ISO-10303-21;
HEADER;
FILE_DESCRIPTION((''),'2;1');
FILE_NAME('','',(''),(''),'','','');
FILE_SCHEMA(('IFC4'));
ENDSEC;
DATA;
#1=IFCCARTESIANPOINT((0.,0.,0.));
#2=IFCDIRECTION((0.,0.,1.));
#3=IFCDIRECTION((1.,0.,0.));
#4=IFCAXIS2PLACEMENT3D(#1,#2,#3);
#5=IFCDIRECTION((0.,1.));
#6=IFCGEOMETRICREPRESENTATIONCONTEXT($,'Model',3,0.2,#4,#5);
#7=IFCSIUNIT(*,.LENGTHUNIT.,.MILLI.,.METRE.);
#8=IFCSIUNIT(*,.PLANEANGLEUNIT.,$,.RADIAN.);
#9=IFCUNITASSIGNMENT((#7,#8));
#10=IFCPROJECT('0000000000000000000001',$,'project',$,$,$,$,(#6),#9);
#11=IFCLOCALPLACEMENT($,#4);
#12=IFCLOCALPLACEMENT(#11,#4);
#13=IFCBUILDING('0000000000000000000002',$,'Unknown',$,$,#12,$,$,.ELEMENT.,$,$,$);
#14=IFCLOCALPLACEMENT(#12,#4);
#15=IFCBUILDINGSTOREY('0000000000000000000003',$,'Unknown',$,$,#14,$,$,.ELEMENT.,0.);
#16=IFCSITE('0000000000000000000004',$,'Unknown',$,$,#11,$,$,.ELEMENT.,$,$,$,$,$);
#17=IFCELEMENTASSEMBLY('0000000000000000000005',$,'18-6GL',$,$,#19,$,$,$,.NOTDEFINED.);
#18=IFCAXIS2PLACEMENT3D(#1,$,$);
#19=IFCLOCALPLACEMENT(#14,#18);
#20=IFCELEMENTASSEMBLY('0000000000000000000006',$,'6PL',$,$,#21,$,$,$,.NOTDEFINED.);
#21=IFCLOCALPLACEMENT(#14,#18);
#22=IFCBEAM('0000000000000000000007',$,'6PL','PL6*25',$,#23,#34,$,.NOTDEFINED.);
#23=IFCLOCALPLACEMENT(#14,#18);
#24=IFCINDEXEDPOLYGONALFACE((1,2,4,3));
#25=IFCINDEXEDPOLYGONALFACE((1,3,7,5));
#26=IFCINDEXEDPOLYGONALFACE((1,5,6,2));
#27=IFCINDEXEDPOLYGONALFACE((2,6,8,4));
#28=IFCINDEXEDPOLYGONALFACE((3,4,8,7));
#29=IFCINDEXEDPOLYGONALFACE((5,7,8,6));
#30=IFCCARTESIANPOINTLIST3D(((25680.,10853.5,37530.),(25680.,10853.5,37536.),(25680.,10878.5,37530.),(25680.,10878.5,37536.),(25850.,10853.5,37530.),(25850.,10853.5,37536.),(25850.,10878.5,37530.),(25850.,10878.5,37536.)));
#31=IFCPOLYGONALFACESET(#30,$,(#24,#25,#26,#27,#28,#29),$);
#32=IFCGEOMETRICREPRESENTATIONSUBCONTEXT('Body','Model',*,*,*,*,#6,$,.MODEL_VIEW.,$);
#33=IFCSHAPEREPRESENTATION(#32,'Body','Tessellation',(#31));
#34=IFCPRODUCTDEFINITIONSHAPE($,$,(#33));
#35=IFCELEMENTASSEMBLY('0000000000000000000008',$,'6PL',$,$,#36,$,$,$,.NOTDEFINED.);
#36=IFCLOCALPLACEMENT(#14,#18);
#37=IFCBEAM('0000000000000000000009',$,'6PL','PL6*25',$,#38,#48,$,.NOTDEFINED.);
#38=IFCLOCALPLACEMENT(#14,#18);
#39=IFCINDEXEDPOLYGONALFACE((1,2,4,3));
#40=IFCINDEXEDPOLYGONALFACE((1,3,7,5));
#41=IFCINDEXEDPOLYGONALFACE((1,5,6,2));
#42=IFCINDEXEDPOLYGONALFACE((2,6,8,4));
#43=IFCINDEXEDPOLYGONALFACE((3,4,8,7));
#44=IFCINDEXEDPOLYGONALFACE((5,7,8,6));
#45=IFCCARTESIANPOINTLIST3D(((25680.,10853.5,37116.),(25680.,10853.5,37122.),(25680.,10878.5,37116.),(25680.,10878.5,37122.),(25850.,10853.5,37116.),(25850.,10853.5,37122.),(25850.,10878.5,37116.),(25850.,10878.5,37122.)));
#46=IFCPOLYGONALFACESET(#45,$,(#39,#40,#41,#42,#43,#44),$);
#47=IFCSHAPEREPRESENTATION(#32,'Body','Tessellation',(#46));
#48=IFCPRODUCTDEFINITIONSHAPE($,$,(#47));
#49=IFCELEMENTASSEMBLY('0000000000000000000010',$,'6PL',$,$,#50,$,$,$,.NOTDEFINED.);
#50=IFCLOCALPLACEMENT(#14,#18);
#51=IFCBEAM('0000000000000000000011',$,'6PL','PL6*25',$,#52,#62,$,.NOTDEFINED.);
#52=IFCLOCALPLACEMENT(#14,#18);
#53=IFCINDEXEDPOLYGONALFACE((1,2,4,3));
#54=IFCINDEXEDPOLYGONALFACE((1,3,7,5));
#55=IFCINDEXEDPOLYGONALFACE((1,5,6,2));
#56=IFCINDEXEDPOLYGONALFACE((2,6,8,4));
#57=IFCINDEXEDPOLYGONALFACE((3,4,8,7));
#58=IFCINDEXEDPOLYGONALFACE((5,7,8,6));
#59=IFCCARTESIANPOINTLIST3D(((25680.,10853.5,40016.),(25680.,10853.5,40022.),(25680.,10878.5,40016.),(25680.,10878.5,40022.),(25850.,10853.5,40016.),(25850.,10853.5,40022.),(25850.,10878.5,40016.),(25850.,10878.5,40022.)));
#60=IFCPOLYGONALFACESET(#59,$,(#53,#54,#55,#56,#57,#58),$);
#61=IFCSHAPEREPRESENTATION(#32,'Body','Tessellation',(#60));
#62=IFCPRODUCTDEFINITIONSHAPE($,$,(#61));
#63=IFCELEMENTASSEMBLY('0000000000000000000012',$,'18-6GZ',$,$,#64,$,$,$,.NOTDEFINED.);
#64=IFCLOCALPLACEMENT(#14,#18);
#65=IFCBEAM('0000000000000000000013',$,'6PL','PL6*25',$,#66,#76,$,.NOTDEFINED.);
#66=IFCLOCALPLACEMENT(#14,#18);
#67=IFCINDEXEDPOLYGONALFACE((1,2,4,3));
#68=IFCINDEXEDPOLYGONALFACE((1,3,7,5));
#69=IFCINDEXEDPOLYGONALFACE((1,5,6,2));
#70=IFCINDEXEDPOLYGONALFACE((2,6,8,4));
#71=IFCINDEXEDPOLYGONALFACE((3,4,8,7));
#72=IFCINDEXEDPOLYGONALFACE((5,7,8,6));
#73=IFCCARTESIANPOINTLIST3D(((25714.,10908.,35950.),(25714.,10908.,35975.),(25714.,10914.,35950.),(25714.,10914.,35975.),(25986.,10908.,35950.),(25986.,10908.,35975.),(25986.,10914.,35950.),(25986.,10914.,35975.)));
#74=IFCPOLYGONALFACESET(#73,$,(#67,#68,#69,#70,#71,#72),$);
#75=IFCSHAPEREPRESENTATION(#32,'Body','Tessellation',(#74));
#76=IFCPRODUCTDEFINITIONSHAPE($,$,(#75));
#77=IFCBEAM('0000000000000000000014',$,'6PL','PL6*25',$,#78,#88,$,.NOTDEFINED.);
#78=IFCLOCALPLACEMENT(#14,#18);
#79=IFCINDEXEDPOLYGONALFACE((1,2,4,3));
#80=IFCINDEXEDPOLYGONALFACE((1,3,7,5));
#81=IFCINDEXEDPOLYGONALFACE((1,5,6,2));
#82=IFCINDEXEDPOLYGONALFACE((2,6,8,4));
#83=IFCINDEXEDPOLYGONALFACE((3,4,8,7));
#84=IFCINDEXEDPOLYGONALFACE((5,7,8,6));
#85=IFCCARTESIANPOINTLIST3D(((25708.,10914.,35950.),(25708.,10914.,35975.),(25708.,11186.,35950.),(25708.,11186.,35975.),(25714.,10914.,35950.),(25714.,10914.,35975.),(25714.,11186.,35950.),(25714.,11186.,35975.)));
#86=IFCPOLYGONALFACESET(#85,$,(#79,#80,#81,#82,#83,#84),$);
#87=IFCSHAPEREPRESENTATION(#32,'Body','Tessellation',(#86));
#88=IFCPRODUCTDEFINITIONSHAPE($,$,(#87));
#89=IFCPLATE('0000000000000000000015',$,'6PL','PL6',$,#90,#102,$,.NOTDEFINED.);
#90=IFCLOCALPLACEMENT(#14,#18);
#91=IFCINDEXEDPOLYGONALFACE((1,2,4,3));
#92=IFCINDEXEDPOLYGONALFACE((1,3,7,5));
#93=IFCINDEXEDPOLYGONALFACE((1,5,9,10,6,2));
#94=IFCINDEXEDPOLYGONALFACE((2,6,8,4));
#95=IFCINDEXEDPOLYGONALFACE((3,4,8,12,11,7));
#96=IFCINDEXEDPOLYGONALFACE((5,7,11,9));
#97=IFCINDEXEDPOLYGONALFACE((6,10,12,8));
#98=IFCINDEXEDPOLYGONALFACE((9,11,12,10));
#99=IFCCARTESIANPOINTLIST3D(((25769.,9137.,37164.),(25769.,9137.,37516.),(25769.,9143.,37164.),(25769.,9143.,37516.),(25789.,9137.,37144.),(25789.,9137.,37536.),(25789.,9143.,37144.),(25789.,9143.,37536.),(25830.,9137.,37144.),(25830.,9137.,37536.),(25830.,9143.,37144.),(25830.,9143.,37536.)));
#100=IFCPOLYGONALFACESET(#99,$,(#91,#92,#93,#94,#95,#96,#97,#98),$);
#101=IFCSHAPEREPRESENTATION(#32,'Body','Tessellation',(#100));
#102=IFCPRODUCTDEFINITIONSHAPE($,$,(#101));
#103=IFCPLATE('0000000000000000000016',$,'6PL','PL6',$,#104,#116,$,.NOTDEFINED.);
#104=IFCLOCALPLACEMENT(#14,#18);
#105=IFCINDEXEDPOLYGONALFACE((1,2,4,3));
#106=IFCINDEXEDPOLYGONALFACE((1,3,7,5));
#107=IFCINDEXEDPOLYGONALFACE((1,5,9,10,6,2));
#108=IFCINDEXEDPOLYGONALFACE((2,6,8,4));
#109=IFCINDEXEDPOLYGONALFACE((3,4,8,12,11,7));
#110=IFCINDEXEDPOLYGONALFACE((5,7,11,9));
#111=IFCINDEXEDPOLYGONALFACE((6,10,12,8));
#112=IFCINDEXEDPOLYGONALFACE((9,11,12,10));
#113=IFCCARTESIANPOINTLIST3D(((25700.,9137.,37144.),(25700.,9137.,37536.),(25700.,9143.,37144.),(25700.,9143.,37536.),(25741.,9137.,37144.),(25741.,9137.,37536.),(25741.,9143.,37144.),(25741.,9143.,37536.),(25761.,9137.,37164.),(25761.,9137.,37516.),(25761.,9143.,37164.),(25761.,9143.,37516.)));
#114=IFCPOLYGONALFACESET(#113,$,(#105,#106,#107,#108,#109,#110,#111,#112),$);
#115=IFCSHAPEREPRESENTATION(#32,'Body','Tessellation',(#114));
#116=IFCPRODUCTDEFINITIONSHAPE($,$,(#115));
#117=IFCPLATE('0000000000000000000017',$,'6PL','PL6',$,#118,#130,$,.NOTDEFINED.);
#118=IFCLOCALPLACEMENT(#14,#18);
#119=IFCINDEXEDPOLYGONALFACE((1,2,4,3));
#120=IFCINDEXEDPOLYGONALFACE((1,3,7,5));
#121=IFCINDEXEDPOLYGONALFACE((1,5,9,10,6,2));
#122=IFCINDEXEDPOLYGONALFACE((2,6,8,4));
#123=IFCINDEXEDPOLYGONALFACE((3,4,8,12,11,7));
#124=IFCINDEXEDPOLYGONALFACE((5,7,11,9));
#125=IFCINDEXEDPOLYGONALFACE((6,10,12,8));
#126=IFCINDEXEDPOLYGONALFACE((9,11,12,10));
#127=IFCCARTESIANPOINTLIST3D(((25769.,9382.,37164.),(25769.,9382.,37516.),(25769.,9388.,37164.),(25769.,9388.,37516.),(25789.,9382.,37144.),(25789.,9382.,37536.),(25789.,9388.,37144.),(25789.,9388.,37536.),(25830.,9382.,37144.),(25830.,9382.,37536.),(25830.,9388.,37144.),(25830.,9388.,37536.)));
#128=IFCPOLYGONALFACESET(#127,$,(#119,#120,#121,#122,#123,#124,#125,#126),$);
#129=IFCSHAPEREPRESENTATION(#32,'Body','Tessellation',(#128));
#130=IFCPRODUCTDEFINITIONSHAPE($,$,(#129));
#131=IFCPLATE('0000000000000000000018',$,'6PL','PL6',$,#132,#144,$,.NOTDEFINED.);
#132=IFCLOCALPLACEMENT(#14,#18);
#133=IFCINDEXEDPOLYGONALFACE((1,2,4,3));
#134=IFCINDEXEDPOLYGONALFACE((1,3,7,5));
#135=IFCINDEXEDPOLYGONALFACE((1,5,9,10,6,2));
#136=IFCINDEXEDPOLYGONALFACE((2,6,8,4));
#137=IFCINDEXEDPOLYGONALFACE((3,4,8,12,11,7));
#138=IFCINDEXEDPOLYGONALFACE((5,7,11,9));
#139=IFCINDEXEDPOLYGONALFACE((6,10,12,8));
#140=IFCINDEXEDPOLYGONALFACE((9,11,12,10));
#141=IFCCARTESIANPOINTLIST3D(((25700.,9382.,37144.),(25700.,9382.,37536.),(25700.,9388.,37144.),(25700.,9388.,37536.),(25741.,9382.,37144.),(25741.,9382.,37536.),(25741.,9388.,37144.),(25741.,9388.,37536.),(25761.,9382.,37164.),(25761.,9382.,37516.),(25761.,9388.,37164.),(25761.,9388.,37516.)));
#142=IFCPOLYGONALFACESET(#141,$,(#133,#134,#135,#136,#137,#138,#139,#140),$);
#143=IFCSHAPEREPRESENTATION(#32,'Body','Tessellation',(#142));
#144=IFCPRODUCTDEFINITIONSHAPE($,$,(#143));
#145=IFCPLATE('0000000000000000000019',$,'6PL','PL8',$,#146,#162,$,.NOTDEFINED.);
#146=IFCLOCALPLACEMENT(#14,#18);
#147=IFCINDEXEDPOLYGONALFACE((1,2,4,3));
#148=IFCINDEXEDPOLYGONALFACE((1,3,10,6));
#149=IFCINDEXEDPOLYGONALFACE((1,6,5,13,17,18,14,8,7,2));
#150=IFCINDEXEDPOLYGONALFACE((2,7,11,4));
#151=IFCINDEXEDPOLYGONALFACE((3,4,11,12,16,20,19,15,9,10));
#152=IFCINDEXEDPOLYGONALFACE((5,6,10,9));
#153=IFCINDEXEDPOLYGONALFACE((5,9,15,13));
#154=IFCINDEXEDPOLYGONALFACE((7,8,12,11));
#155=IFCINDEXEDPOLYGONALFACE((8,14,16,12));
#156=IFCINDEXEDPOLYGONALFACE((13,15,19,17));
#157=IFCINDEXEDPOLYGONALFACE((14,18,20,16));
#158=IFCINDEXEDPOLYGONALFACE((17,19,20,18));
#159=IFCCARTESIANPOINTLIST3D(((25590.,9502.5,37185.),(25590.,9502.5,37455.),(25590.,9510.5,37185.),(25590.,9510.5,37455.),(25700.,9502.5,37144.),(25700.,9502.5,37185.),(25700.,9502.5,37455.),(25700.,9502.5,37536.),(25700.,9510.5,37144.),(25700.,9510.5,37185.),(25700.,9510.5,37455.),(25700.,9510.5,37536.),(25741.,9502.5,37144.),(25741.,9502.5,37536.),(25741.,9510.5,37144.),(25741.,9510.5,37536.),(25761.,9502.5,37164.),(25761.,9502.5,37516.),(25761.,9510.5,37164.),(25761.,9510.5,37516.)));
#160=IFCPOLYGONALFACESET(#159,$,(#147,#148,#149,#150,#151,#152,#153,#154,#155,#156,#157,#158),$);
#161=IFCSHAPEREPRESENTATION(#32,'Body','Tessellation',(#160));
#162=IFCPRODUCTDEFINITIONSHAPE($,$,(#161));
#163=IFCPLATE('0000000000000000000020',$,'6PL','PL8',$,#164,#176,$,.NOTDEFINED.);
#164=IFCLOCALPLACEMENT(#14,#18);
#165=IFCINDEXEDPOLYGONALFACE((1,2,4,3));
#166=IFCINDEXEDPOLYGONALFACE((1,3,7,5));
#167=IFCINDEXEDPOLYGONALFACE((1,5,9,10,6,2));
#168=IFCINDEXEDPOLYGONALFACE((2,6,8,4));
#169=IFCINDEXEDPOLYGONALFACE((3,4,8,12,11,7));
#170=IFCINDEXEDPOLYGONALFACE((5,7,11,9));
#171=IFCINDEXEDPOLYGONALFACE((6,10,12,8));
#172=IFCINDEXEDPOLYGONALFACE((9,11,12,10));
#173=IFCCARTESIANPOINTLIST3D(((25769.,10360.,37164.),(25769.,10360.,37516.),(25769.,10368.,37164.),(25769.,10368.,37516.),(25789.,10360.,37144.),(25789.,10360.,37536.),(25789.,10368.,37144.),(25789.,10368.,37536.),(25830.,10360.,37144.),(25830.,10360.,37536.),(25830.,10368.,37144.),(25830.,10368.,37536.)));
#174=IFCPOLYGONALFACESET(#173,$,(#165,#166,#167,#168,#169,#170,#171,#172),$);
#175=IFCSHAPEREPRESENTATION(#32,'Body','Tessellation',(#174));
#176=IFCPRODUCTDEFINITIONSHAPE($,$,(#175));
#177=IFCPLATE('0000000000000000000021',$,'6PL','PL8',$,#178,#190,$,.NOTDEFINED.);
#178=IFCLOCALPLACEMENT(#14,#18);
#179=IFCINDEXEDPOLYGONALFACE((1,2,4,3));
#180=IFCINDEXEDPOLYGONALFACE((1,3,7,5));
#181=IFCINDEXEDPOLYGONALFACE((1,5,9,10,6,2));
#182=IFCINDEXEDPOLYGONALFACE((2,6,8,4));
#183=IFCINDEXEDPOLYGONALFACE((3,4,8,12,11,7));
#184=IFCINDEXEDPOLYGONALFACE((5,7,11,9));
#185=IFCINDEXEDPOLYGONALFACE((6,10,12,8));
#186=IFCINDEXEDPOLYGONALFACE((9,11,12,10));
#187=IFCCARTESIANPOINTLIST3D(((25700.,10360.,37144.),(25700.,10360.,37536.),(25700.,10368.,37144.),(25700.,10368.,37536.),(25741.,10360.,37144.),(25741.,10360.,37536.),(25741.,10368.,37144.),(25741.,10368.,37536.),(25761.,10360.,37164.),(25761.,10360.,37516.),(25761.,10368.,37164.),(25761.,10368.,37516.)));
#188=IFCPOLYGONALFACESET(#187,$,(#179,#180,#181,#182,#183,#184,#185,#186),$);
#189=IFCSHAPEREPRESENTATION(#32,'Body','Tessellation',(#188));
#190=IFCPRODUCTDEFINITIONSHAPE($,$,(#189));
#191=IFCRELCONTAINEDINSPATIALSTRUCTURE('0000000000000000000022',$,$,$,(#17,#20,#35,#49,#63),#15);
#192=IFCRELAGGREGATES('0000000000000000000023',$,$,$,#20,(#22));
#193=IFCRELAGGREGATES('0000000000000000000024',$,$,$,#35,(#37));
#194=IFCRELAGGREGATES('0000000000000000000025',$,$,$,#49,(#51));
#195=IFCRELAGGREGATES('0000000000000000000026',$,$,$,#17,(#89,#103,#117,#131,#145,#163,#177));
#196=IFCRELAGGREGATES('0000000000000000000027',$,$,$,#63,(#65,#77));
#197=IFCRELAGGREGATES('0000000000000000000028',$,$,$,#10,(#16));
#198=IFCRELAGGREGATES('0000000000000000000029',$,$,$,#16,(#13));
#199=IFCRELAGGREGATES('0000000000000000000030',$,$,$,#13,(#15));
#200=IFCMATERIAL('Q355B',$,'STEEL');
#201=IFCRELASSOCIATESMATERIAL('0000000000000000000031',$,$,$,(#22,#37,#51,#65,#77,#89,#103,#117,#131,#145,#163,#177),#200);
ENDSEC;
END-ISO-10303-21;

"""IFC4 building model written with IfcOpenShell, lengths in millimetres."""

from ifc_helpers import new_model, si_unit, direction, frame, origin_with_axes, place, context, subcontext, project, spatial, line, indexed_curve, outline, extrude, material, element, aggregate, save


model = new_model("IFC4")

# Units and contexts
model_context = context("Model", 3, precision=0.2, world=origin_with_axes(), true_north=direction((0.0, 1.0)))
body_context = subcontext(model_context, "Body", "Model", "MODEL_VIEW")
ifc_project = project(units=[si_unit("LENGTHUNIT", "METRE", prefix="MILLI"), si_unit("PLANEANGLEUNIT", "RADIAN")], contexts=[model_context])

# Site, building, storey
site_placement = place(None, origin_with_axes())
site = spatial("IfcSite", under=ifc_project, at=site_placement, Name="Unknown", CompositionType="ELEMENT")
building_placement = place(site_placement, origin_with_axes())
building = spatial("IfcBuilding", under=site, at=building_placement, Name="Unknown", CompositionType="ELEMENT")
storey_placement = place(building_placement, origin_with_axes())
storey = spatial("IfcBuildingStorey", under=building, at=storey_placement, Name="Unknown", CompositionType="ELEMENT", Elevation=0.0)

# Element assembly
assembly_1_placement = place(storey_placement, frame((25765.0, 10900.0, 37340.0), z_axis=(-1.0, 0.0, 0.0), x_axis=(0.0, -1.0, 0.0)))
assembly_1 = element("IfcElementAssembly", 1, at=assembly_1_placement, inside=storey, Name="18-6GL", PredefinedType="NOTDEFINED")
ifc_material_1 = material(Name="Q355B", Category="STEEL")

# Element assemblies, beams
assembly_2_placement = place(storey_placement, frame((25680.0, 10866.0, 37533.0), z_axis=(0.0, 0.0, -1.0), x_axis=(1.0, 0.0, 0.0)))
assembly_2 = element("IfcElementAssembly", 2, at=assembly_2_placement, inside=storey, Name="6PL", PredefinedType="NOTDEFINED")
beam_1_placement = place(assembly_2_placement, origin_with_axes())
beam_1 = element("IfcBeam", 3, at=beam_1_placement, material=ifc_material_1, Name="6PL", Description="PL6*25", PredefinedType="NOTDEFINED", context=body_context, shape_type="SolidModel", body=[
    extrude(outline(indexed_curve([(-3.0, -12.5), (3.0, -12.5), (3.0, 12.5), (-3.0, 12.5)], segments=[line(1, 2, 3, 4, 1)])), frame((0.0, 0.0, 0.0), z_axis=(-1.0, 0.0, 0.0), x_axis=(0.0, 0.0, 1.0)), (0.0, 0.0, -1.0), 170.0),
])
aggregate(assembly_2, [beam_1])
assembly_3_placement = place(storey_placement, frame((25680.0, 10866.0, 37119.0), z_axis=(0.0, 0.0, -1.0), x_axis=(1.0, 0.0, 0.0)))
assembly_3 = element("IfcElementAssembly", 4, at=assembly_3_placement, inside=storey, Name="6PL", PredefinedType="NOTDEFINED")
beam_2_placement = place(assembly_3_placement, origin_with_axes())
beam_2 = element("IfcBeam", 5, at=beam_2_placement, material=ifc_material_1, Name="6PL", Description="PL6*25", PredefinedType="NOTDEFINED", context=body_context, shape_type="SolidModel", body=[
    extrude(outline(indexed_curve([(-3.0, -12.5), (3.0, -12.5), (3.0, 12.5), (-3.0, 12.5)], segments=[line(1, 2, 3, 4, 1)])), frame((0.0, 0.0, 0.0), z_axis=(-1.0, 0.0, 0.0), x_axis=(0.0, 0.0, 1.0)), (0.0, 0.0, -1.0), 170.0),
])
aggregate(assembly_3, [beam_2])
assembly_4_placement = place(storey_placement, frame((25680.0, 10866.0, 40019.0), z_axis=(0.0, 0.0, -1.0), x_axis=(1.0, 0.0, 0.0)))
assembly_4 = element("IfcElementAssembly", 6, at=assembly_4_placement, inside=storey, Name="6PL", PredefinedType="NOTDEFINED")
beam_3_placement = place(assembly_4_placement, origin_with_axes())
beam_3 = element("IfcBeam", 7, at=beam_3_placement, material=ifc_material_1, Name="6PL", Description="PL6*25", PredefinedType="NOTDEFINED", context=body_context, shape_type="SolidModel", body=[
    extrude(outline(indexed_curve([(-3.0, -12.5), (3.0, -12.5), (3.0, 12.5), (-3.0, 12.5)], segments=[line(1, 2, 3, 4, 1)])), frame((0.0, 0.0, 0.0), z_axis=(-1.0, 0.0, 0.0), x_axis=(0.0, 0.0, 1.0)), (0.0, 0.0, -1.0), 170.0),
])
aggregate(assembly_4, [beam_3])

# Element assembly, beams
assembly_5_placement = place(storey_placement, frame((25850.0, 11050.0, 35950.0), z_axis=(-1.0, 0.0, 0.0), x_axis=(0.0, 0.0, 1.0)))
assembly_5 = element("IfcElementAssembly", 8, at=assembly_5_placement, inside=storey, Name="18-6GZ", PredefinedType="NOTDEFINED")
beam_4_placement = place(assembly_5_placement, frame((12.5, -139.0, 136.0), z_axis=(0.0, -1.0, 0.0), x_axis=(0.0, 0.0, -1.0)))
beam_4 = element("IfcBeam", 9, at=beam_4_placement, material=ifc_material_1, Name="6PL", Description="PL6*25", PredefinedType="NOTDEFINED", context=body_context, shape_type="SolidModel", body=[
    extrude(outline(indexed_curve([(-3.0, -12.5), (3.0, -12.5), (3.0, 12.5), (-3.0, 12.5)], segments=[line(1, 2, 3, 4, 1)])), frame((0.0, 0.0, 0.0), z_axis=(-1.0, 0.0, 0.0), x_axis=(0.0, 0.0, 1.0)), (0.0, 0.0, -1.0), 272.0),
])
beam_5_placement = place(assembly_5_placement, frame((12.5, 136.0, 139.0), z_axis=(0.0, 0.0, 1.0), x_axis=(0.0, -1.0, 0.0)))
beam_5 = element("IfcBeam", 10, at=beam_5_placement, material=ifc_material_1, Name="6PL", Description="PL6*25", PredefinedType="NOTDEFINED", context=body_context, shape_type="SolidModel", body=[
    extrude(outline(indexed_curve([(-3.0, -12.5), (3.0, -12.5), (3.0, 12.5), (-3.0, 12.5)], segments=[line(1, 2, 3, 4, 1)])), frame((0.0, 0.0, 0.0), z_axis=(-1.0, 0.0, 0.0), x_axis=(0.0, 0.0, 1.0)), (0.0, 0.0, -1.0), 272.0),
])

# Plates
plate_1_placement = place(assembly_1_placement, frame((1760.0, -196.0, -65.0), z_axis=(-1.0, 0.0, 0.0), x_axis=(0.0, 0.0, 1.0)))
plate_1 = element("IfcPlate", 11, at=plate_1_placement, material=ifc_material_1, Name="6PL", Description="PL6", PredefinedType="NOTDEFINED", context=body_context, shape_type="SolidModel", body=[
    extrude(outline(indexed_curve([(0.0, 0.0), (41.0, 0.0), (61.0, 20.0), (61.0, 372.0), (41.0, 392.0), (0.0, 392.0)], segments=[line(1, 2, 3, 4, 5, 6, 1)])), frame((0.0, 0.0, 3.0), z_axis=(0.0, 0.0, 1.0), x_axis=(1.0, 0.0, 0.0)), (0.0, 0.0, -1.0), 6.0),
])
plate_2_placement = place(assembly_1_placement, frame((1760.0, -196.0, 4.0), z_axis=(-1.0, 0.0, 0.0), x_axis=(0.0, 0.0, 1.0)))
plate_2 = element("IfcPlate", 12, at=plate_2_placement, material=ifc_material_1, Name="6PL", Description="PL6", PredefinedType="NOTDEFINED", context=body_context, shape_type="SolidModel", body=[
    extrude(outline(indexed_curve([(0.0, 20.0), (20.0, 0.0), (61.0, 0.0), (61.0, 392.0), (20.0, 392.0), (0.0, 372.0)], segments=[line(1, 2, 3, 4, 5, 6, 1)])), frame((0.0, 0.0, 3.0), z_axis=(0.0, 0.0, 1.0), x_axis=(1.0, 0.0, 0.0)), (0.0, 0.0, -1.0), 6.0),
])
plate_3_placement = place(assembly_1_placement, frame((1515.0, -196.0, -65.0), z_axis=(-1.0, 0.0, 0.0), x_axis=(0.0, 0.0, 1.0)))
plate_3 = element("IfcPlate", 13, at=plate_3_placement, material=ifc_material_1, Name="6PL", Description="PL6", PredefinedType="NOTDEFINED", context=body_context, shape_type="SolidModel", body=[
    extrude(outline(indexed_curve([(0.0, 0.0), (41.0, 0.0), (61.0, 20.0), (61.0, 372.0), (41.0, 392.0), (0.0, 392.0)], segments=[line(1, 2, 3, 4, 5, 6, 1)])), frame((0.0, 0.0, 3.0), z_axis=(0.0, 0.0, 1.0), x_axis=(1.0, 0.0, 0.0)), (0.0, 0.0, -1.0), 6.0),
])
plate_4_placement = place(assembly_1_placement, frame((1515.0, -196.0, 4.0), z_axis=(-1.0, 0.0, 0.0), x_axis=(0.0, 0.0, 1.0)))
plate_4 = element("IfcPlate", 14, at=plate_4_placement, material=ifc_material_1, Name="6PL", Description="PL6", PredefinedType="NOTDEFINED", context=body_context, shape_type="SolidModel", body=[
    extrude(outline(indexed_curve([(0.0, 20.0), (20.0, 0.0), (61.0, 0.0), (61.0, 392.0), (20.0, 392.0), (0.0, 372.0)], segments=[line(1, 2, 3, 4, 5, 6, 1)])), frame((0.0, 0.0, 3.0), z_axis=(0.0, 0.0, 1.0), x_axis=(1.0, 0.0, 0.0)), (0.0, 0.0, -1.0), 6.0),
])
plate_5_placement = place(assembly_1_placement, frame((1393.5, -176.0, 4.0), z_axis=(-1.0, 0.0, 0.0), x_axis=(0.0, -0.707107, 0.707107)))
plate_5 = element("IfcPlate", 15, at=plate_5_placement, material=ifc_material_1, Name="6PL", Description="PL8", PredefinedType="NOTDEFINED", context=body_context, shape_type="SolidModel", body=[
    extrude(outline(indexed_curve([(0.0, 0.0), (28.3, 0.0), (57.3, 29.0), (28.3, 58.0), (106.1, 135.8), (-84.9, 326.7), (-162.6, 248.9), (-219.9, 306.2), (-248.9, 277.2), (-248.9, 248.9)], segments=[line(1, 2, 3, 4, 5, 6, 7, 8, 9, 10, 1)])), frame((0.0, 0.0, 4.0), z_axis=(0.0, 0.0, 1.0), x_axis=(1.0, 0.0, 0.0)), (0.0, 0.0, -1.0), 8.0),
])
plate_6_placement = place(assembly_1_placement, frame((536.0, -196.0, -65.0), z_axis=(-1.0, 0.0, 0.0), x_axis=(0.0, 0.0, 1.0)))
plate_6 = element("IfcPlate", 16, at=plate_6_placement, material=ifc_material_1, Name="6PL", Description="PL8", PredefinedType="NOTDEFINED", context=body_context, shape_type="SolidModel", body=[
    extrude(outline(indexed_curve([(0.0, 0.0), (41.0, 0.0), (61.0, 20.0), (61.0, 372.0), (41.0, 392.0), (0.0, 392.0)], segments=[line(1, 2, 3, 4, 5, 6, 1)])), frame((0.0, 0.0, 4.0), z_axis=(0.0, 0.0, 1.0), x_axis=(1.0, 0.0, 0.0)), (0.0, 0.0, -1.0), 8.0),
])
plate_7_placement = place(assembly_1_placement, frame((536.0, -196.0, 4.0), z_axis=(-1.0, 0.0, 0.0), x_axis=(0.0, 0.0, 1.0)))
plate_7 = element("IfcPlate", 17, at=plate_7_placement, material=ifc_material_1, Name="6PL", Description="PL8", PredefinedType="NOTDEFINED", context=body_context, shape_type="SolidModel", body=[
    extrude(outline(indexed_curve([(0.0, 20.0), (20.0, 0.0), (61.0, 0.0), (61.0, 392.0), (20.0, 392.0), (0.0, 372.0)], segments=[line(1, 2, 3, 4, 5, 6, 1)])), frame((0.0, 0.0, 4.0), z_axis=(0.0, 0.0, 1.0), x_axis=(1.0, 0.0, 0.0)), (0.0, 0.0, -1.0), 8.0),
])

aggregate(assembly_1, [plate_1, plate_2, plate_3, plate_4, plate_5, plate_6, plate_7])
aggregate(assembly_5, [beam_4, beam_5])

save(model, "model.ifc")
